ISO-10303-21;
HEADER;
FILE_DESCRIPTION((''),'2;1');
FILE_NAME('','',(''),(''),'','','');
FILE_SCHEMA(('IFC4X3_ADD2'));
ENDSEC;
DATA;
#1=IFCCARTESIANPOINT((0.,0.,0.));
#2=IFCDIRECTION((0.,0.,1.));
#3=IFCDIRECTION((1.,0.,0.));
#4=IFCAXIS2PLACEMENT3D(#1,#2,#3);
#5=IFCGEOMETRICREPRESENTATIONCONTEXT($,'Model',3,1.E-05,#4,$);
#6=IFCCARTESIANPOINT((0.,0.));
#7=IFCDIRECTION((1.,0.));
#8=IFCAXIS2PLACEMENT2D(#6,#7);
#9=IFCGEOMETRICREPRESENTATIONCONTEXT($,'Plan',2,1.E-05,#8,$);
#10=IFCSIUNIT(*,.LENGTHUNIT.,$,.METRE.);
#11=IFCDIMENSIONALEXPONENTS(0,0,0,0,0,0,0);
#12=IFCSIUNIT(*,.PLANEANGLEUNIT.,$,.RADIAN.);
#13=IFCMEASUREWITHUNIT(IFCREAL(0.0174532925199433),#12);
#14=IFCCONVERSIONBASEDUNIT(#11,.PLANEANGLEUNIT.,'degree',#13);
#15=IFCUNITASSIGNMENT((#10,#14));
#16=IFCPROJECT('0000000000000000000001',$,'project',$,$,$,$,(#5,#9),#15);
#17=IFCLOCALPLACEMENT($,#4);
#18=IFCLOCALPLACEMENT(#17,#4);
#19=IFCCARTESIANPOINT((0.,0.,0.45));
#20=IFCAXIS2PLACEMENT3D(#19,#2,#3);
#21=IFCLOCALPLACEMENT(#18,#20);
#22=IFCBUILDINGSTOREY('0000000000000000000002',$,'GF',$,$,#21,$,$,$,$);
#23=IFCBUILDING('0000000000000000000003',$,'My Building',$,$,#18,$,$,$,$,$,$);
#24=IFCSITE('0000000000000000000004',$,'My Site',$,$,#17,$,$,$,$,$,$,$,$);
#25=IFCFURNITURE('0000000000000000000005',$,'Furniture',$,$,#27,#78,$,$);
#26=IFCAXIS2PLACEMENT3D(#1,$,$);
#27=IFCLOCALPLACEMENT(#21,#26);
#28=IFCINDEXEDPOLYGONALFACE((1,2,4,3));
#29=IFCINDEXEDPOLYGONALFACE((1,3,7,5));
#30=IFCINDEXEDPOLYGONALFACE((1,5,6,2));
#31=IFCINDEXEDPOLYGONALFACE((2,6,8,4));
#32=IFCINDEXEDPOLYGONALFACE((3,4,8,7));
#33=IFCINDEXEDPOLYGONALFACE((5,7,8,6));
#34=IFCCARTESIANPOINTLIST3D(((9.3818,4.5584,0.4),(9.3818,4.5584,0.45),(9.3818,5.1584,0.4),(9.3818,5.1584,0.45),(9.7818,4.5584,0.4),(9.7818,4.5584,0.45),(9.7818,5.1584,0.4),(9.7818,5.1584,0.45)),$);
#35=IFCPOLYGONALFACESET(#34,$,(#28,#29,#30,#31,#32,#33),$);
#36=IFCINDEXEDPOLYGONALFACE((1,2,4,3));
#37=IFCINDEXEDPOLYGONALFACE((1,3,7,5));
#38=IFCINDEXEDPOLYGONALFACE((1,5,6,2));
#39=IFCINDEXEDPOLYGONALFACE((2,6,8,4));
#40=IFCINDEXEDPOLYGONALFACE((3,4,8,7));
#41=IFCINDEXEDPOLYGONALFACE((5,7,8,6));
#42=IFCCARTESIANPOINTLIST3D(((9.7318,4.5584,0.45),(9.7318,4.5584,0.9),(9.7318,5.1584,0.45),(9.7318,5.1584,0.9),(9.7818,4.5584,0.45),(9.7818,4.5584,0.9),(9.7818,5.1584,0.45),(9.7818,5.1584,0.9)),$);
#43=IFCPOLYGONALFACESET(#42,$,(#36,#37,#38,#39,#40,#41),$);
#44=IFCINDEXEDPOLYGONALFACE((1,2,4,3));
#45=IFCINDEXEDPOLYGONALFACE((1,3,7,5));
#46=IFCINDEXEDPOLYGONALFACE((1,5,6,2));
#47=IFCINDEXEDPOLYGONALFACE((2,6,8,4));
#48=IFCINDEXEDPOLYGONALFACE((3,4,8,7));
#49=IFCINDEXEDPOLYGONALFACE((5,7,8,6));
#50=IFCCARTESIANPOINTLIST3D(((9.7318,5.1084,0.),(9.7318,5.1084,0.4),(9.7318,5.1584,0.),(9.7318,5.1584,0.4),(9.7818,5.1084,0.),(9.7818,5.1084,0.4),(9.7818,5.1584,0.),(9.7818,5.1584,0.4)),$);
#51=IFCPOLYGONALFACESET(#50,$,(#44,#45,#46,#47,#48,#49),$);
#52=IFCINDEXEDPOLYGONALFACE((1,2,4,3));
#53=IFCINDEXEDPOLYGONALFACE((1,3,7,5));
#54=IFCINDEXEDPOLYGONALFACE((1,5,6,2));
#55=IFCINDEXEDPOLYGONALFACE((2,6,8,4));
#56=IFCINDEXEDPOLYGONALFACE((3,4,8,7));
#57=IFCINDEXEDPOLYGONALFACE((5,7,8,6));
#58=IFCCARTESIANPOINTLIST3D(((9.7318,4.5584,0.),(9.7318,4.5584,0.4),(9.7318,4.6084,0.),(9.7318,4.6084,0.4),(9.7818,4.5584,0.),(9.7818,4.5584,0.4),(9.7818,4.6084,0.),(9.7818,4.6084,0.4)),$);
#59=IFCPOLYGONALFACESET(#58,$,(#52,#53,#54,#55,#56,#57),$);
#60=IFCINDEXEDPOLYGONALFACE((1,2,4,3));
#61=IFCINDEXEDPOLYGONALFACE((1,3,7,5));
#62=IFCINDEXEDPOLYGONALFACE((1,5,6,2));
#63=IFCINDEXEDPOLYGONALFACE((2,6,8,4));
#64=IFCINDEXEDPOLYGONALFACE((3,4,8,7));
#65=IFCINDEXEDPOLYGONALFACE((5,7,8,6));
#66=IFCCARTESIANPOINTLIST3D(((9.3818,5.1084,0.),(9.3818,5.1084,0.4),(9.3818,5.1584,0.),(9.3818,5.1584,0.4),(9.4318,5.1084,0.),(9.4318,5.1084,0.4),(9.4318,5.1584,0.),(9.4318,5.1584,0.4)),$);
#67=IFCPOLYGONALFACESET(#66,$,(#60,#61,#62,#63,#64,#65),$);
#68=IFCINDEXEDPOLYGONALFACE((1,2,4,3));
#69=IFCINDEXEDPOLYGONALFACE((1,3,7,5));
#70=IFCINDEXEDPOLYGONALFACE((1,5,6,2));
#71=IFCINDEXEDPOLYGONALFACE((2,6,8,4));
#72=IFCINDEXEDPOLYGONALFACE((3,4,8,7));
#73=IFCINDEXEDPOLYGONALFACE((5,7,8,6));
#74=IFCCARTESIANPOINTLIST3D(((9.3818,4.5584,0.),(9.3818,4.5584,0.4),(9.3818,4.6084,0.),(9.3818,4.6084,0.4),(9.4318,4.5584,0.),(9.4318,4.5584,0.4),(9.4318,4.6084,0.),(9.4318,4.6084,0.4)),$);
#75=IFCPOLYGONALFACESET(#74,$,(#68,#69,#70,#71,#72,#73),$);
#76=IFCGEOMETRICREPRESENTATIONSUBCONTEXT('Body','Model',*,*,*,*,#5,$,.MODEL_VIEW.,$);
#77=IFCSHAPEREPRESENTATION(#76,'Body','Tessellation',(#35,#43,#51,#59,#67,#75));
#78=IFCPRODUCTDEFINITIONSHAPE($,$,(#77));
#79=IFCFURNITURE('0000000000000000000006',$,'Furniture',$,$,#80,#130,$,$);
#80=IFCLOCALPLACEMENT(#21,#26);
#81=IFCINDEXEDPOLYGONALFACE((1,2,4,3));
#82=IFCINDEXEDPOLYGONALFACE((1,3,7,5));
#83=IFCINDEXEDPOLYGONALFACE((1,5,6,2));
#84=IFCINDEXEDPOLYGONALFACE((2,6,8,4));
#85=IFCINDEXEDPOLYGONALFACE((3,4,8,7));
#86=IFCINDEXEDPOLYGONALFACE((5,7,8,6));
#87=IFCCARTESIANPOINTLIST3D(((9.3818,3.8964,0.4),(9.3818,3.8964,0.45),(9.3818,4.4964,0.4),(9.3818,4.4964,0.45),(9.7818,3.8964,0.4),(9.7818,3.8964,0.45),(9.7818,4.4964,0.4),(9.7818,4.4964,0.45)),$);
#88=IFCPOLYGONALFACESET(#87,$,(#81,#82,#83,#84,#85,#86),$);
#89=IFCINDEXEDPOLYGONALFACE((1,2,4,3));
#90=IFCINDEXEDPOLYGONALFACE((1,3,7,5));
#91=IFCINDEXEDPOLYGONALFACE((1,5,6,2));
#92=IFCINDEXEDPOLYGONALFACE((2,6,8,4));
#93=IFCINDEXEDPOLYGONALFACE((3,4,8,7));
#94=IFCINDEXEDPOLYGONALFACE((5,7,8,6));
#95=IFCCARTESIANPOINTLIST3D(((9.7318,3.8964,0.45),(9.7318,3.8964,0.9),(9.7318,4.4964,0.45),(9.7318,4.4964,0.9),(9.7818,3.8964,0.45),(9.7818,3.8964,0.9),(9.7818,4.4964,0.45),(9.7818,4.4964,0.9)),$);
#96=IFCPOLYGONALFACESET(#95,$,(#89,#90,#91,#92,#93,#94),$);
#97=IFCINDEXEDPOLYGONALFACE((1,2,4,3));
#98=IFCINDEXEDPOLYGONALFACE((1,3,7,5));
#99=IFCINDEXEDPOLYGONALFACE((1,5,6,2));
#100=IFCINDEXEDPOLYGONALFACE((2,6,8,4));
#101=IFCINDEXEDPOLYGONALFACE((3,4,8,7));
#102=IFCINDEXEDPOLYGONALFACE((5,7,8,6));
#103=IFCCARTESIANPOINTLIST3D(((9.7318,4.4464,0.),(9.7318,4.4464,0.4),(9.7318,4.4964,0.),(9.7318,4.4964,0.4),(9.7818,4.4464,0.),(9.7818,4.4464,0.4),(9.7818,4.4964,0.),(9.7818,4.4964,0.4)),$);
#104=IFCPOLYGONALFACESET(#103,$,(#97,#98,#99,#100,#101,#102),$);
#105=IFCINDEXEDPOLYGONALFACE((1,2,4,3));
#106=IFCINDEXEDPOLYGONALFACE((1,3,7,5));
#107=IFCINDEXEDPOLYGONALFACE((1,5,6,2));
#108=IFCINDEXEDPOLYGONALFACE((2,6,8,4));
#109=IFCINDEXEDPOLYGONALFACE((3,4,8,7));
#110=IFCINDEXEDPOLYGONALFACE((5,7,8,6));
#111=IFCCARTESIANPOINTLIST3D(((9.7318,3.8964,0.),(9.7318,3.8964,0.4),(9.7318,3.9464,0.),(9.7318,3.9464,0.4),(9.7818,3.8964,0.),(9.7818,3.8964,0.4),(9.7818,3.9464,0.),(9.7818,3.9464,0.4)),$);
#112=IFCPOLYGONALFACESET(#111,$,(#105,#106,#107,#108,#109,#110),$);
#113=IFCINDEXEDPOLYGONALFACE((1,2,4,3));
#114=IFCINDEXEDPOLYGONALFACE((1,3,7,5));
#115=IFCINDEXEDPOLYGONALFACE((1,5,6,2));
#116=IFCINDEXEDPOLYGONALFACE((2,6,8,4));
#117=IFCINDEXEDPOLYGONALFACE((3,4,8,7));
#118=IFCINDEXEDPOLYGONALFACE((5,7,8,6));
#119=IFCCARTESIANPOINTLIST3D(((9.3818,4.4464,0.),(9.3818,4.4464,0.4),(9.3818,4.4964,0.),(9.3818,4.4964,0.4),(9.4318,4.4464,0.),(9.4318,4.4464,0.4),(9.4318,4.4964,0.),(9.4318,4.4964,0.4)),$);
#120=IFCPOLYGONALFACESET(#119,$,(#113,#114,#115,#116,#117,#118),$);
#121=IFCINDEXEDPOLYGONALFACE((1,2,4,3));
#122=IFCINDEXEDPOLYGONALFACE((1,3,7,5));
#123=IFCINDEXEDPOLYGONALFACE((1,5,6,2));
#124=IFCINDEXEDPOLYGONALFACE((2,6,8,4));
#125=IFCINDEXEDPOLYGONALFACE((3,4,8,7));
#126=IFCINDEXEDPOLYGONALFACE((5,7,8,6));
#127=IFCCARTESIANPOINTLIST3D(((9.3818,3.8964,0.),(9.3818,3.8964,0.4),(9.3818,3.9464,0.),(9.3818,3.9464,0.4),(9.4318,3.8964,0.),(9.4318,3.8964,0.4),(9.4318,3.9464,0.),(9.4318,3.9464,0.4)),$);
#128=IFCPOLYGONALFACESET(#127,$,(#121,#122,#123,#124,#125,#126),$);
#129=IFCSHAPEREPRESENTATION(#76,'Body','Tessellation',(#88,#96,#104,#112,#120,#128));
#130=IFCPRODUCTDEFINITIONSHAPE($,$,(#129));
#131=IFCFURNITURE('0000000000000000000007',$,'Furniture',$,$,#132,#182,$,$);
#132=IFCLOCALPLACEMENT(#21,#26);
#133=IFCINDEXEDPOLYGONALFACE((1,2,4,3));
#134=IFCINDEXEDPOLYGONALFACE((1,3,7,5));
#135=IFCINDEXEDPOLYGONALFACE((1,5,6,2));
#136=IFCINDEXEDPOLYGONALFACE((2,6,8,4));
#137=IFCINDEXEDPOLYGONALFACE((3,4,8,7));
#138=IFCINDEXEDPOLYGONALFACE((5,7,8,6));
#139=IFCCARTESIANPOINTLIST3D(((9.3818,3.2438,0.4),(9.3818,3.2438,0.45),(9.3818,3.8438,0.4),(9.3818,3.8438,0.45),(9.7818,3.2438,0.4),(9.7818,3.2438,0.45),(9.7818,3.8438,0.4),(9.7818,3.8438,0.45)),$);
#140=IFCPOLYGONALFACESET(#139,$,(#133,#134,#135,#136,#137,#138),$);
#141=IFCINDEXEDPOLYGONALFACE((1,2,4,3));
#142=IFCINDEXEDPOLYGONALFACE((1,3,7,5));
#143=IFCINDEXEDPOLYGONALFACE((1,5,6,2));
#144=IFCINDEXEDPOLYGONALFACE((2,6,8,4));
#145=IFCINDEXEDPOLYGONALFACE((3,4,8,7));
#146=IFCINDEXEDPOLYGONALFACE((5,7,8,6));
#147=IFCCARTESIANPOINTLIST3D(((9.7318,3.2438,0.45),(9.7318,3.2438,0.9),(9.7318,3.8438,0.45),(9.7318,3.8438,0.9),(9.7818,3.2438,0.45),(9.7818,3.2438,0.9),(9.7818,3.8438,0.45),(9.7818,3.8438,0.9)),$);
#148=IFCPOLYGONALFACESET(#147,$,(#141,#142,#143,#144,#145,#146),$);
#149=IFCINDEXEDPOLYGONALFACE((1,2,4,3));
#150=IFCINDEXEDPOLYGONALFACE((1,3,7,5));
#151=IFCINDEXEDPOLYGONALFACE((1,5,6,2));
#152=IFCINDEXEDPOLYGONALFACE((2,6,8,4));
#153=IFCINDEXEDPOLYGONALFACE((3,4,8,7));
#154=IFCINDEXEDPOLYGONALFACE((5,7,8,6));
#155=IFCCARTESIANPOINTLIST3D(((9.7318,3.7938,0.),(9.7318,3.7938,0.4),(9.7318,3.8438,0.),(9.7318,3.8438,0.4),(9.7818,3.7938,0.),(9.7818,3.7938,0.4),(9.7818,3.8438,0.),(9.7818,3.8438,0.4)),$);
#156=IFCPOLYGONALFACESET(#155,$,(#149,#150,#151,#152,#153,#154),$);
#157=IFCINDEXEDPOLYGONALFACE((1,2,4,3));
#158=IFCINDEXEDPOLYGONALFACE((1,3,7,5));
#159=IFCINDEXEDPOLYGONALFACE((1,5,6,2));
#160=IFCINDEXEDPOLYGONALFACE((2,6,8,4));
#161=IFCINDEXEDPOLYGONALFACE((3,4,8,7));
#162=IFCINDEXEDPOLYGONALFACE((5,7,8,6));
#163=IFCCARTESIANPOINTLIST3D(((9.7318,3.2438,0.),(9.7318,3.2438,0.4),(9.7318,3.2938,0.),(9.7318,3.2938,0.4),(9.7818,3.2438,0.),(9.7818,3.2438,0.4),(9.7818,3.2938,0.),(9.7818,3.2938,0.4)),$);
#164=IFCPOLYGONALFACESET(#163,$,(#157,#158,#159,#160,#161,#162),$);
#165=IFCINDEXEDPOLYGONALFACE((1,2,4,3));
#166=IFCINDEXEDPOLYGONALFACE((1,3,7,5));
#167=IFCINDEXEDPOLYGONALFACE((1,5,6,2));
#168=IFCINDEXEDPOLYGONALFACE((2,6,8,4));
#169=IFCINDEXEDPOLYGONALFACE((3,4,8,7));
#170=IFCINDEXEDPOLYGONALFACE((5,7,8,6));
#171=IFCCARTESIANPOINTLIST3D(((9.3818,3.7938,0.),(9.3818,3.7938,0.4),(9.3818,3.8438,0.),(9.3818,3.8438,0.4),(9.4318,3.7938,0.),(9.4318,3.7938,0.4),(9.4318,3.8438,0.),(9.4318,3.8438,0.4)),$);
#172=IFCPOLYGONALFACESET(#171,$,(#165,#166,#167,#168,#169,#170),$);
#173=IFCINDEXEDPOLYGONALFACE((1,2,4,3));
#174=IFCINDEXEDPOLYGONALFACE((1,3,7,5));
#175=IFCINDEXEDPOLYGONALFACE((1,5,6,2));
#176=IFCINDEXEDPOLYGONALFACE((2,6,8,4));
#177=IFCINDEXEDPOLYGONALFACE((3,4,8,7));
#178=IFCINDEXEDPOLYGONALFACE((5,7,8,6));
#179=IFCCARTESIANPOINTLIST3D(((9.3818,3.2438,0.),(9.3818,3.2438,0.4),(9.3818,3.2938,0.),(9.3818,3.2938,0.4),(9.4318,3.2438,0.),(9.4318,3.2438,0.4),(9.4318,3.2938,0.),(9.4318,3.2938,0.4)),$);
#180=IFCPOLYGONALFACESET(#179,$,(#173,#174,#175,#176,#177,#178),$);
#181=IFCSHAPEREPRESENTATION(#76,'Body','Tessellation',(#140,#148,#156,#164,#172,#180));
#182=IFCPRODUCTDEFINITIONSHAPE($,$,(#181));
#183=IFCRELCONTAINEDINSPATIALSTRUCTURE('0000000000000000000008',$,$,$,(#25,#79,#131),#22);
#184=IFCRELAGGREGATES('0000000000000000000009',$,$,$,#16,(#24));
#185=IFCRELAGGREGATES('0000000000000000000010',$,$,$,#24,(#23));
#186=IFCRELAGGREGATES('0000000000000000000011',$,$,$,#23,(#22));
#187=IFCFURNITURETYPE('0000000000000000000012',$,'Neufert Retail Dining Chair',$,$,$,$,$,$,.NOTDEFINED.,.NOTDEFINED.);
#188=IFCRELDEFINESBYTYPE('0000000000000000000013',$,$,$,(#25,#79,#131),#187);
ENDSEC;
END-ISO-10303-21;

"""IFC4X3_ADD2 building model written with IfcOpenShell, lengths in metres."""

from ifc_helpers import new_model, entity, si_unit, converted_unit, frame, origin_with_axes, origin_2d_with_axis, place, context, subcontext, project, spatial, line, indexed_curve, outline, extrude, shape, source, transform, mapped, type_object, type_shapes, element, save


model = new_model("IFC4X3_ADD2")

# Units and contexts
model_context = context("Model", 3, precision=1e-05, world=origin_with_axes())
plan_context = context("Plan", 2, precision=1e-05, world=origin_2d_with_axis())
body_context_1 = subcontext(model_context, "Body", "Model", "MODEL_VIEW")
body_context_2 = subcontext(plan_context, "Body", "Plan", "PLAN_VIEW")
ifc_project = project(units=[si_unit("LENGTHUNIT", "METRE"), converted_unit("PLANEANGLEUNIT", "degree", entity("IfcReal", 0.0174532925199433), si_unit("PLANEANGLEUNIT", "RADIAN"), dimensions=[0, 0, 0, 0, 0, 0, 0])], contexts=[model_context, plan_context])

# Site, building, storey
site_placement = place(None, origin_with_axes())
site = spatial("IfcSite", under=ifc_project, at=site_placement, Name="My Site")
building_placement = place(site_placement, origin_with_axes())
building = spatial("IfcBuilding", under=site, at=building_placement, Name="My Building")
storey_placement = place(building_placement, frame((0.0, 0.0, 0.45), z_axis=(0.0, 0.0, 1.0), x_axis=(1.0, 0.0, 0.0)))
storey = spatial("IfcBuildingStorey", under=building, at=storey_placement, Name="GF")

# Furniture
furniture_type_1 = type_object("IfcFurnitureType", Name="Neufert Retail Dining Chair", AssemblyPlace="NOTDEFINED", PredefinedType="NOTDEFINED")
shared_shape_1 = source(origin_with_axes(), body_context_1, "Body", "SweptSolid", [
    extrude(outline(indexed_curve([(-0.3, 0.0), (0.3, 0.0), (0.3, -0.4), (-0.3, -0.4)], segments=[line(1, 2, 3, 4, 1)])), frame((0.0, 0.0, 0.45), z_axis=(0.0, 0.0, 1.0), x_axis=(1.0, 0.0, 0.0)), (0.0, 0.0, -1.0), 0.05),
    extrude(outline(indexed_curve([(-0.3, 0.0), (0.3, 0.0), (0.3, -0.05), (-0.3, -0.05)], segments=[line(1, 2, 3, 4, 1)])), frame((0.0, 0.0, 0.9), z_axis=(0.0, 0.0, 1.0), x_axis=(1.0, 0.0, 0.0)), (0.0, 0.0, -1.0), 0.45),
    extrude(outline(indexed_curve([(-0.3, 0.0), (-0.25, 0.0), (-0.25, -0.05), (-0.3, -0.05)], segments=[line(1, 2, 3, 4, 1)])), origin_with_axes(), (0.0, 0.0, 1.0), 0.4),
    extrude(outline(indexed_curve([(0.3, 0.0), (0.25, 0.0), (0.25, -0.05), (0.3, -0.05)], segments=[line(1, 2, 3, 4, 1)])), origin_with_axes(), (0.0, 0.0, 1.0), 0.4),
    extrude(outline(indexed_curve([(-0.3, -0.4), (-0.25, -0.4), (-0.25, -0.35), (-0.3, -0.35)], segments=[line(1, 2, 3, 4, 1)])), origin_with_axes(), (0.0, 0.0, 1.0), 0.4),
    extrude(outline(indexed_curve([(0.3, -0.4), (0.25, -0.4), (0.25, -0.35), (0.3, -0.35)], segments=[line(1, 2, 3, 4, 1)])), origin_with_axes(), (0.0, 0.0, 1.0), 0.4),
])
shared_shape_2 = source(origin_with_axes(), body_context_2, "Body", "Curve2D", [
    entity("IfcIndexedPolyCurve", entity("IfcCartesianPointList2D", [[-0.3, -0.4], [0.3, -0.4]])),
    entity("IfcIndexedPolyCurve", entity("IfcCartesianPointList2D", [[-0.3, -0.4], [-0.3, -0.3], [-0.2121, -0.0879], [0.0, 0.0], [0.2121, -0.0879], [0.3, -0.3], [0.3, -0.4]]), [entity("IfcLineIndex", [1, 2]), entity("IfcArcIndex", [2, 3, 4]), entity("IfcArcIndex", [4, 5, 6]), entity("IfcLineIndex", [6, 7])]),
    entity("IfcIndexedPolyCurve", entity("IfcCartesianPointList2D", [[-0.26, -0.4], [-0.26, -0.3], [-0.1838, -0.1162], [0.0, -0.04], [0.1838, -0.1162], [0.26, -0.3], [0.26, -0.4]]), [entity("IfcLineIndex", [1, 2]), entity("IfcArcIndex", [2, 3, 4]), entity("IfcArcIndex", [4, 5, 6]), entity("IfcLineIndex", [6, 7])]),
])
type_shapes(furniture_type_1, [shared_shape_1, shared_shape_2])
for number, where, z_axis, x_axis, name in (
    (1, (9.7818, 4.8584, 0.0), (0.0, 0.0, 1.0), (-0.000001, -1.0, 0.0), "Furniture"),
    (2, (9.7818, 4.1964, 0.0), (0.0, 0.0, 1.0), (-0.000001, -1.0, 0.0), "Furniture"),
    (3, (9.7818, 3.5438, 0.0), (0.0, 0.0, 1.0), (-0.000001, -1.0, 0.0), "Furniture"),
):
    element("IfcFurniture", number, at=place(storey_placement, frame(where, z_axis=z_axis, x_axis=x_axis)), inside=storey, type_object=furniture_type_1, Name=name, shapes=[
        shape(body_context_1, "Body", "MappedRepresentation", [mapped(shared_shape_1, transform((0.0, 0.0, 0.0), x_axis=(1.0, 0.0, 0.0), y_axis=(0.0, 1.0, 0.0), z_axis=(0.0, 0.0, 1.0), scale=1.0))]),
        shape(body_context_2, "Body", "MappedRepresentation", [mapped(shared_shape_2, transform((0.0, 0.0, 0.0), x_axis=(1.0, 0.0, 0.0), y_axis=(0.0, 1.0, 0.0), z_axis=(0.0, 0.0, 1.0), scale=1.0))]),
    ])

save(model, "model.ifc")
